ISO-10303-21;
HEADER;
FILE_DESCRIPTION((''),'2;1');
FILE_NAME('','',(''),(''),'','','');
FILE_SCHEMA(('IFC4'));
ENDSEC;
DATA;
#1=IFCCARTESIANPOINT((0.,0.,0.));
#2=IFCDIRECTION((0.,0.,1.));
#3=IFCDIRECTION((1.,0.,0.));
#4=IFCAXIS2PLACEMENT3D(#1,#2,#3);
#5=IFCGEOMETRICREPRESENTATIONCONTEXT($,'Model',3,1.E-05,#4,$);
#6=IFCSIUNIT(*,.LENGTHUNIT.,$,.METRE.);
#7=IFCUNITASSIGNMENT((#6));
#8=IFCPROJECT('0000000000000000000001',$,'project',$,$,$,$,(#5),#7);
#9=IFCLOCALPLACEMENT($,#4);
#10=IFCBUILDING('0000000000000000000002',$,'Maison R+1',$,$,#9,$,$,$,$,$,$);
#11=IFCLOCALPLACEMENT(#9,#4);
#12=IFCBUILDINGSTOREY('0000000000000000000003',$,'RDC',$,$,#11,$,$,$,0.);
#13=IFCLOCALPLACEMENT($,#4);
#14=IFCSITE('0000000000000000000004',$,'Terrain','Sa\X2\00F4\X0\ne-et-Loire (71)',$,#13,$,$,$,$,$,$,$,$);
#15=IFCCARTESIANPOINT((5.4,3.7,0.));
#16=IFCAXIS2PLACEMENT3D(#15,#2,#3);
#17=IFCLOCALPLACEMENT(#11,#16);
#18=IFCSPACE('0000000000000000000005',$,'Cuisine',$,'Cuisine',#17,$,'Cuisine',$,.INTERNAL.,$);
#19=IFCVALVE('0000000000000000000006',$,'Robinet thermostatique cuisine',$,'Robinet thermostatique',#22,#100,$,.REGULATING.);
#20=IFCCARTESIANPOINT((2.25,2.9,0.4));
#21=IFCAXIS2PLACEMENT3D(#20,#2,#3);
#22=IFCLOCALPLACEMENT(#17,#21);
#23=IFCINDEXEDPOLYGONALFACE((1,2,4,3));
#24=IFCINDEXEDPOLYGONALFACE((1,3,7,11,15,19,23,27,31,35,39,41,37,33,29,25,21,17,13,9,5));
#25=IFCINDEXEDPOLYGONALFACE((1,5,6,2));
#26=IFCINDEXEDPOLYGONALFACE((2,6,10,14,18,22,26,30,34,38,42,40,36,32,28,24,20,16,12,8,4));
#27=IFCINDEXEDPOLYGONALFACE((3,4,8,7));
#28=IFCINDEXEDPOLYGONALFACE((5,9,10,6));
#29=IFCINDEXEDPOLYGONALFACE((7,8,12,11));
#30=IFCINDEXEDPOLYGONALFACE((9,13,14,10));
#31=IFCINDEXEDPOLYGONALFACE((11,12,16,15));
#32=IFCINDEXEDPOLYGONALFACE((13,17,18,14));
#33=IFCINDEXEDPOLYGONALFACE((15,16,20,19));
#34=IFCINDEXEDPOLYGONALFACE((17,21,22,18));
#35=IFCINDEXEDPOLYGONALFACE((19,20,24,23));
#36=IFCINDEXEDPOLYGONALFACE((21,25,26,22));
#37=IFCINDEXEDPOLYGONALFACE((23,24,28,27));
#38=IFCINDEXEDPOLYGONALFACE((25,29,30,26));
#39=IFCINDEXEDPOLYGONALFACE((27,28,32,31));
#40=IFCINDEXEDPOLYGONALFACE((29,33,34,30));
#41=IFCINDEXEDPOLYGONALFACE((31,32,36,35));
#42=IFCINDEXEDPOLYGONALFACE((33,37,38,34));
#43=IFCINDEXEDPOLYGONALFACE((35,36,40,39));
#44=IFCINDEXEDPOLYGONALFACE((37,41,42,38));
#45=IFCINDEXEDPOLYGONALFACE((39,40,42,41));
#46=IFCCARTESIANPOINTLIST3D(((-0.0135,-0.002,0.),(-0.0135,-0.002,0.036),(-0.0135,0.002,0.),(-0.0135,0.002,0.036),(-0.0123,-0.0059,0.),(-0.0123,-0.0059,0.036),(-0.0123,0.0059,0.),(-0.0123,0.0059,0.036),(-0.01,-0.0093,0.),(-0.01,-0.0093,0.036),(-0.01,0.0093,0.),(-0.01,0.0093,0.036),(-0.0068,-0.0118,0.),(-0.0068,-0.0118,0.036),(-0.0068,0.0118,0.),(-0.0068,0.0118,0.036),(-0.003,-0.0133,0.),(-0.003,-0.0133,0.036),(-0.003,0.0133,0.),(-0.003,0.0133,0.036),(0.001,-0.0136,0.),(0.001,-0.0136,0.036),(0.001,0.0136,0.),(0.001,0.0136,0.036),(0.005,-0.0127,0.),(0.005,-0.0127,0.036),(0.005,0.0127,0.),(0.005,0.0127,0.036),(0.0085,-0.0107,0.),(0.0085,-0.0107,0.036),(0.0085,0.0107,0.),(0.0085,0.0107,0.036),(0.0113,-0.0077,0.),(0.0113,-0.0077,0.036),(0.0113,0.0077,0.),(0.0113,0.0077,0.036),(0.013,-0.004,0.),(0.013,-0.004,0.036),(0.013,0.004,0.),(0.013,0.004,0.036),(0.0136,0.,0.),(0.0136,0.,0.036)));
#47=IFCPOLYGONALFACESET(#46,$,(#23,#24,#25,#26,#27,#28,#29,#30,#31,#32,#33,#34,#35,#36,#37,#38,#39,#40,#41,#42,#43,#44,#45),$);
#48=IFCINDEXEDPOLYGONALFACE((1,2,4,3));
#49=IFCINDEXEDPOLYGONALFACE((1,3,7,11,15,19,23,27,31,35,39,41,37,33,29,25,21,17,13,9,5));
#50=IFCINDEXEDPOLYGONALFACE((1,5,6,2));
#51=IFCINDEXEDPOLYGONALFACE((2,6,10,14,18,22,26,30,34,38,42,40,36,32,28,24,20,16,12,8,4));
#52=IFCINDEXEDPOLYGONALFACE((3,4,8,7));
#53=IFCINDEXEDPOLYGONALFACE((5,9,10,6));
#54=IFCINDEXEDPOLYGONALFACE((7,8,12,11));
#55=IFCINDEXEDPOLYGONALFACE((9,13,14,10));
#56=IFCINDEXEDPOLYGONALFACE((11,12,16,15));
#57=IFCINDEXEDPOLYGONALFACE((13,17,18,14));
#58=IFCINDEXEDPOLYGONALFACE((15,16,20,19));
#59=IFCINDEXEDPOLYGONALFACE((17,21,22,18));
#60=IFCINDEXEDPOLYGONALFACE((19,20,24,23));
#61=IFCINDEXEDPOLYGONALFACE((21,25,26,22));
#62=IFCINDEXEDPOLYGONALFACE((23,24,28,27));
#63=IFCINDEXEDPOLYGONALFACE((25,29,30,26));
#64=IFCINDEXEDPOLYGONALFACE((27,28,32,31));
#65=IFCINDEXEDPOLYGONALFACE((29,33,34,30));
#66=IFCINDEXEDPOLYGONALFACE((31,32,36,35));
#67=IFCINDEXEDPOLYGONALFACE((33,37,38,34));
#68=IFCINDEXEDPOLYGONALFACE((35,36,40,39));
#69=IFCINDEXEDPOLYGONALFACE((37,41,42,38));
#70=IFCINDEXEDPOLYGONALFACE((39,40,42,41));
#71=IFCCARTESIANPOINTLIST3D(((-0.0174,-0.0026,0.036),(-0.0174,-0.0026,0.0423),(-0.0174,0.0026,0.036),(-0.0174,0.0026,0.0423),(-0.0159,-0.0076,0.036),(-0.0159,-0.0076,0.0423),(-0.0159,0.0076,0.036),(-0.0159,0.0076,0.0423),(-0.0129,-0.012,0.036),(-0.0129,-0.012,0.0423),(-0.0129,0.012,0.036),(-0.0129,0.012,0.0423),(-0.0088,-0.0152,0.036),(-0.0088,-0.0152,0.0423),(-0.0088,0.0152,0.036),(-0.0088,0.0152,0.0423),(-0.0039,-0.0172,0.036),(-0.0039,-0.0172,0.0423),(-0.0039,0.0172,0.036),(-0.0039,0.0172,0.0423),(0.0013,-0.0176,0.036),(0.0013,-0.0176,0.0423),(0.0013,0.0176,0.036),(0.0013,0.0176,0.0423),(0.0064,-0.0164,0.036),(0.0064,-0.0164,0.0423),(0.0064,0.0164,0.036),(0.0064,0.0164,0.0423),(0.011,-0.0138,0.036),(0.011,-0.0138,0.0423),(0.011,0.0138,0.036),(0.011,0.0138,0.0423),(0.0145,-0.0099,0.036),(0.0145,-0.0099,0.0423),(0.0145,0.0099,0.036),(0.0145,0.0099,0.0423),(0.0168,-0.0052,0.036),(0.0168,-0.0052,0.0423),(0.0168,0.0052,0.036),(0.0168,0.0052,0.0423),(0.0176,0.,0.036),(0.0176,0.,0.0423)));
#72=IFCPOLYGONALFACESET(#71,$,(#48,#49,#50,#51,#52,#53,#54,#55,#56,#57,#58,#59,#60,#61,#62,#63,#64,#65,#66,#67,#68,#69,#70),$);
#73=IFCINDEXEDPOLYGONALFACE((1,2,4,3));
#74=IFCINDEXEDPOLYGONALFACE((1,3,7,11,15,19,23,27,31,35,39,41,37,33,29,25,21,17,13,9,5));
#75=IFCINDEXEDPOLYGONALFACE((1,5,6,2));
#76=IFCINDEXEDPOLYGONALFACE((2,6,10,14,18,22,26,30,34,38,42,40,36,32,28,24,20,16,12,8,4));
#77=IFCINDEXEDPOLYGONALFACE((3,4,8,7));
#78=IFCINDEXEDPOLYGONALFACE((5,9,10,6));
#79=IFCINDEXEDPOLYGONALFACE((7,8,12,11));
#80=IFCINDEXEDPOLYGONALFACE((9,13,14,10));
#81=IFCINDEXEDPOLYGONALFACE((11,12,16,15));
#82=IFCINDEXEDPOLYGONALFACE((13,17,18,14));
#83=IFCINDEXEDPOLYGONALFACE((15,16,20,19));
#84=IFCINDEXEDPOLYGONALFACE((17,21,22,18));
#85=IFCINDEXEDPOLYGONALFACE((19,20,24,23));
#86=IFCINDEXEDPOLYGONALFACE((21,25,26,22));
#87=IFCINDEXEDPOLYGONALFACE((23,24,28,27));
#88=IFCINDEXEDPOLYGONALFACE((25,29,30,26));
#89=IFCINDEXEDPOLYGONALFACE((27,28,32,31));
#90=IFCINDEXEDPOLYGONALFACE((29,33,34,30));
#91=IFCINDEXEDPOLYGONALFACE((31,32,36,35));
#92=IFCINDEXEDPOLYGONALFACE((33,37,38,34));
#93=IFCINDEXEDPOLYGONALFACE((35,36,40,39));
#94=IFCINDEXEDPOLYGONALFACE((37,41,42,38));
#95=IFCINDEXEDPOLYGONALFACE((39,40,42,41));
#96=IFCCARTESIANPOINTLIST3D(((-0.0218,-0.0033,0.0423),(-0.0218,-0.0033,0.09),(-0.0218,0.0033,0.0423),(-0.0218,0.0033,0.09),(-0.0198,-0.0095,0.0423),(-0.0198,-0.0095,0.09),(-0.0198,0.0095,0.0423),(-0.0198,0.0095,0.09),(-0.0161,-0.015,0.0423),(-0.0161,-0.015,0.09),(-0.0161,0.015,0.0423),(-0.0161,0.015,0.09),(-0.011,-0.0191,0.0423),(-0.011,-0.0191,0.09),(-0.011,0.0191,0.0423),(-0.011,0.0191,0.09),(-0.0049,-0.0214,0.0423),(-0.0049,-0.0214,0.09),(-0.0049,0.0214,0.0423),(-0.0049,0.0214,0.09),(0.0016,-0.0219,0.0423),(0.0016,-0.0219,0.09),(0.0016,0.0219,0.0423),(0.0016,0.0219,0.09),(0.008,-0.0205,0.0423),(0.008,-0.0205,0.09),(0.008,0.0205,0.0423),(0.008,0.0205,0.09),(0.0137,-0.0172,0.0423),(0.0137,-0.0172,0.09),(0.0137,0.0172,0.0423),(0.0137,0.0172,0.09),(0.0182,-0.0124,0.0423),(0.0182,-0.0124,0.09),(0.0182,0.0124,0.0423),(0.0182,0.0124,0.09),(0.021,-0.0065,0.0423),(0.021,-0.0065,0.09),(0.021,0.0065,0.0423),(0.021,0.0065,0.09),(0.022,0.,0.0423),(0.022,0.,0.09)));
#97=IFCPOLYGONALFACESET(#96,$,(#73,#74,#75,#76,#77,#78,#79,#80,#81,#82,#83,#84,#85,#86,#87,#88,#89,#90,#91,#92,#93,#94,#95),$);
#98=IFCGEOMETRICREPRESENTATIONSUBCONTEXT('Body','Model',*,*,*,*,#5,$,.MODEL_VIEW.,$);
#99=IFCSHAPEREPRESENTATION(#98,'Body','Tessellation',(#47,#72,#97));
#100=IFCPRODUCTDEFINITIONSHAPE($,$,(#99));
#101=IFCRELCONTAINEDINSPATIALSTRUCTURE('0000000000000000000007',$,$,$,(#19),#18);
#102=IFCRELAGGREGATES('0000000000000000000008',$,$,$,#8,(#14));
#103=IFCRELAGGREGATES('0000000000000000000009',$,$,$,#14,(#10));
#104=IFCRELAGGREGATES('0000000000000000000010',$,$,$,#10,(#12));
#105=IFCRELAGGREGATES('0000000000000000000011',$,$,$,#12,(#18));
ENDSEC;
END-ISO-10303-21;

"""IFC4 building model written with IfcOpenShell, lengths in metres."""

from ifc_helpers import new_model, si_unit, frame, origin_with_axes, place, context, subcontext, project, spatial, circle, extrude, element, save


model = new_model("IFC4")

# Units and contexts
model_context = context("Model", 3, precision=1e-05, world=origin_with_axes())
body_context = subcontext(model_context, "Body", "Model", "MODEL_VIEW")
ifc_project = project(units=[si_unit("LENGTHUNIT", "METRE")], contexts=[model_context])

# Site, building, storey
site_placement = place(None, origin_with_axes())
site = spatial("IfcSite", under=ifc_project, at=site_placement, Name="Terrain", Description="Saône-et-Loire (71)")
building_placement = place(None, origin_with_axes())
building = spatial("IfcBuilding", under=site, at=building_placement, Name="Maison R+1")
storey_placement = place(building_placement, origin_with_axes())
storey = spatial("IfcBuildingStorey", under=building, at=storey_placement, Name="RDC", Elevation=0.0)

# Shared definitions
space_1_placement = place(storey_placement, frame((5.4, 3.7, 0.0), z_axis=(0.0, 0.0, 1.0), x_axis=(1.0, 0.0, 0.0)))
space_1 = spatial("IfcSpace", under=storey, at=space_1_placement, Name="Cuisine", ObjectType="Cuisine", LongName="Cuisine", PredefinedType="INTERNAL")

# Valve
valve_1_placement = place(space_1_placement, frame((2.25, 2.9, 0.4), z_axis=(0.0, 0.0, 1.0), x_axis=(1.0, 0.0, 0.0)))
element("IfcValve", 1, at=valve_1_placement, inside=space_1, Name="Robinet thermostatique cuisine", ObjectType="Robinet thermostatique", PredefinedType="REGULATING", context=body_context, shape_type="SweptSolid", body=[
    extrude(circle(Radius=0.0136), origin_with_axes(), (0.0, 0.0, 1.0), 0.036),
    extrude(circle(Radius=0.0176), frame((0.0, 0.0, 0.036), z_axis=(0.0, 0.0, 1.0), x_axis=(1.0, 0.0, 0.0)), (0.0, 0.0, 1.0), 0.0063),
    extrude(circle(Radius=0.022), frame((0.0, 0.0, 0.0423), z_axis=(0.0, 0.0, 1.0), x_axis=(1.0, 0.0, 0.0)), (0.0, 0.0, 1.0), 0.0477),
])

save(model, "model.ifc")
